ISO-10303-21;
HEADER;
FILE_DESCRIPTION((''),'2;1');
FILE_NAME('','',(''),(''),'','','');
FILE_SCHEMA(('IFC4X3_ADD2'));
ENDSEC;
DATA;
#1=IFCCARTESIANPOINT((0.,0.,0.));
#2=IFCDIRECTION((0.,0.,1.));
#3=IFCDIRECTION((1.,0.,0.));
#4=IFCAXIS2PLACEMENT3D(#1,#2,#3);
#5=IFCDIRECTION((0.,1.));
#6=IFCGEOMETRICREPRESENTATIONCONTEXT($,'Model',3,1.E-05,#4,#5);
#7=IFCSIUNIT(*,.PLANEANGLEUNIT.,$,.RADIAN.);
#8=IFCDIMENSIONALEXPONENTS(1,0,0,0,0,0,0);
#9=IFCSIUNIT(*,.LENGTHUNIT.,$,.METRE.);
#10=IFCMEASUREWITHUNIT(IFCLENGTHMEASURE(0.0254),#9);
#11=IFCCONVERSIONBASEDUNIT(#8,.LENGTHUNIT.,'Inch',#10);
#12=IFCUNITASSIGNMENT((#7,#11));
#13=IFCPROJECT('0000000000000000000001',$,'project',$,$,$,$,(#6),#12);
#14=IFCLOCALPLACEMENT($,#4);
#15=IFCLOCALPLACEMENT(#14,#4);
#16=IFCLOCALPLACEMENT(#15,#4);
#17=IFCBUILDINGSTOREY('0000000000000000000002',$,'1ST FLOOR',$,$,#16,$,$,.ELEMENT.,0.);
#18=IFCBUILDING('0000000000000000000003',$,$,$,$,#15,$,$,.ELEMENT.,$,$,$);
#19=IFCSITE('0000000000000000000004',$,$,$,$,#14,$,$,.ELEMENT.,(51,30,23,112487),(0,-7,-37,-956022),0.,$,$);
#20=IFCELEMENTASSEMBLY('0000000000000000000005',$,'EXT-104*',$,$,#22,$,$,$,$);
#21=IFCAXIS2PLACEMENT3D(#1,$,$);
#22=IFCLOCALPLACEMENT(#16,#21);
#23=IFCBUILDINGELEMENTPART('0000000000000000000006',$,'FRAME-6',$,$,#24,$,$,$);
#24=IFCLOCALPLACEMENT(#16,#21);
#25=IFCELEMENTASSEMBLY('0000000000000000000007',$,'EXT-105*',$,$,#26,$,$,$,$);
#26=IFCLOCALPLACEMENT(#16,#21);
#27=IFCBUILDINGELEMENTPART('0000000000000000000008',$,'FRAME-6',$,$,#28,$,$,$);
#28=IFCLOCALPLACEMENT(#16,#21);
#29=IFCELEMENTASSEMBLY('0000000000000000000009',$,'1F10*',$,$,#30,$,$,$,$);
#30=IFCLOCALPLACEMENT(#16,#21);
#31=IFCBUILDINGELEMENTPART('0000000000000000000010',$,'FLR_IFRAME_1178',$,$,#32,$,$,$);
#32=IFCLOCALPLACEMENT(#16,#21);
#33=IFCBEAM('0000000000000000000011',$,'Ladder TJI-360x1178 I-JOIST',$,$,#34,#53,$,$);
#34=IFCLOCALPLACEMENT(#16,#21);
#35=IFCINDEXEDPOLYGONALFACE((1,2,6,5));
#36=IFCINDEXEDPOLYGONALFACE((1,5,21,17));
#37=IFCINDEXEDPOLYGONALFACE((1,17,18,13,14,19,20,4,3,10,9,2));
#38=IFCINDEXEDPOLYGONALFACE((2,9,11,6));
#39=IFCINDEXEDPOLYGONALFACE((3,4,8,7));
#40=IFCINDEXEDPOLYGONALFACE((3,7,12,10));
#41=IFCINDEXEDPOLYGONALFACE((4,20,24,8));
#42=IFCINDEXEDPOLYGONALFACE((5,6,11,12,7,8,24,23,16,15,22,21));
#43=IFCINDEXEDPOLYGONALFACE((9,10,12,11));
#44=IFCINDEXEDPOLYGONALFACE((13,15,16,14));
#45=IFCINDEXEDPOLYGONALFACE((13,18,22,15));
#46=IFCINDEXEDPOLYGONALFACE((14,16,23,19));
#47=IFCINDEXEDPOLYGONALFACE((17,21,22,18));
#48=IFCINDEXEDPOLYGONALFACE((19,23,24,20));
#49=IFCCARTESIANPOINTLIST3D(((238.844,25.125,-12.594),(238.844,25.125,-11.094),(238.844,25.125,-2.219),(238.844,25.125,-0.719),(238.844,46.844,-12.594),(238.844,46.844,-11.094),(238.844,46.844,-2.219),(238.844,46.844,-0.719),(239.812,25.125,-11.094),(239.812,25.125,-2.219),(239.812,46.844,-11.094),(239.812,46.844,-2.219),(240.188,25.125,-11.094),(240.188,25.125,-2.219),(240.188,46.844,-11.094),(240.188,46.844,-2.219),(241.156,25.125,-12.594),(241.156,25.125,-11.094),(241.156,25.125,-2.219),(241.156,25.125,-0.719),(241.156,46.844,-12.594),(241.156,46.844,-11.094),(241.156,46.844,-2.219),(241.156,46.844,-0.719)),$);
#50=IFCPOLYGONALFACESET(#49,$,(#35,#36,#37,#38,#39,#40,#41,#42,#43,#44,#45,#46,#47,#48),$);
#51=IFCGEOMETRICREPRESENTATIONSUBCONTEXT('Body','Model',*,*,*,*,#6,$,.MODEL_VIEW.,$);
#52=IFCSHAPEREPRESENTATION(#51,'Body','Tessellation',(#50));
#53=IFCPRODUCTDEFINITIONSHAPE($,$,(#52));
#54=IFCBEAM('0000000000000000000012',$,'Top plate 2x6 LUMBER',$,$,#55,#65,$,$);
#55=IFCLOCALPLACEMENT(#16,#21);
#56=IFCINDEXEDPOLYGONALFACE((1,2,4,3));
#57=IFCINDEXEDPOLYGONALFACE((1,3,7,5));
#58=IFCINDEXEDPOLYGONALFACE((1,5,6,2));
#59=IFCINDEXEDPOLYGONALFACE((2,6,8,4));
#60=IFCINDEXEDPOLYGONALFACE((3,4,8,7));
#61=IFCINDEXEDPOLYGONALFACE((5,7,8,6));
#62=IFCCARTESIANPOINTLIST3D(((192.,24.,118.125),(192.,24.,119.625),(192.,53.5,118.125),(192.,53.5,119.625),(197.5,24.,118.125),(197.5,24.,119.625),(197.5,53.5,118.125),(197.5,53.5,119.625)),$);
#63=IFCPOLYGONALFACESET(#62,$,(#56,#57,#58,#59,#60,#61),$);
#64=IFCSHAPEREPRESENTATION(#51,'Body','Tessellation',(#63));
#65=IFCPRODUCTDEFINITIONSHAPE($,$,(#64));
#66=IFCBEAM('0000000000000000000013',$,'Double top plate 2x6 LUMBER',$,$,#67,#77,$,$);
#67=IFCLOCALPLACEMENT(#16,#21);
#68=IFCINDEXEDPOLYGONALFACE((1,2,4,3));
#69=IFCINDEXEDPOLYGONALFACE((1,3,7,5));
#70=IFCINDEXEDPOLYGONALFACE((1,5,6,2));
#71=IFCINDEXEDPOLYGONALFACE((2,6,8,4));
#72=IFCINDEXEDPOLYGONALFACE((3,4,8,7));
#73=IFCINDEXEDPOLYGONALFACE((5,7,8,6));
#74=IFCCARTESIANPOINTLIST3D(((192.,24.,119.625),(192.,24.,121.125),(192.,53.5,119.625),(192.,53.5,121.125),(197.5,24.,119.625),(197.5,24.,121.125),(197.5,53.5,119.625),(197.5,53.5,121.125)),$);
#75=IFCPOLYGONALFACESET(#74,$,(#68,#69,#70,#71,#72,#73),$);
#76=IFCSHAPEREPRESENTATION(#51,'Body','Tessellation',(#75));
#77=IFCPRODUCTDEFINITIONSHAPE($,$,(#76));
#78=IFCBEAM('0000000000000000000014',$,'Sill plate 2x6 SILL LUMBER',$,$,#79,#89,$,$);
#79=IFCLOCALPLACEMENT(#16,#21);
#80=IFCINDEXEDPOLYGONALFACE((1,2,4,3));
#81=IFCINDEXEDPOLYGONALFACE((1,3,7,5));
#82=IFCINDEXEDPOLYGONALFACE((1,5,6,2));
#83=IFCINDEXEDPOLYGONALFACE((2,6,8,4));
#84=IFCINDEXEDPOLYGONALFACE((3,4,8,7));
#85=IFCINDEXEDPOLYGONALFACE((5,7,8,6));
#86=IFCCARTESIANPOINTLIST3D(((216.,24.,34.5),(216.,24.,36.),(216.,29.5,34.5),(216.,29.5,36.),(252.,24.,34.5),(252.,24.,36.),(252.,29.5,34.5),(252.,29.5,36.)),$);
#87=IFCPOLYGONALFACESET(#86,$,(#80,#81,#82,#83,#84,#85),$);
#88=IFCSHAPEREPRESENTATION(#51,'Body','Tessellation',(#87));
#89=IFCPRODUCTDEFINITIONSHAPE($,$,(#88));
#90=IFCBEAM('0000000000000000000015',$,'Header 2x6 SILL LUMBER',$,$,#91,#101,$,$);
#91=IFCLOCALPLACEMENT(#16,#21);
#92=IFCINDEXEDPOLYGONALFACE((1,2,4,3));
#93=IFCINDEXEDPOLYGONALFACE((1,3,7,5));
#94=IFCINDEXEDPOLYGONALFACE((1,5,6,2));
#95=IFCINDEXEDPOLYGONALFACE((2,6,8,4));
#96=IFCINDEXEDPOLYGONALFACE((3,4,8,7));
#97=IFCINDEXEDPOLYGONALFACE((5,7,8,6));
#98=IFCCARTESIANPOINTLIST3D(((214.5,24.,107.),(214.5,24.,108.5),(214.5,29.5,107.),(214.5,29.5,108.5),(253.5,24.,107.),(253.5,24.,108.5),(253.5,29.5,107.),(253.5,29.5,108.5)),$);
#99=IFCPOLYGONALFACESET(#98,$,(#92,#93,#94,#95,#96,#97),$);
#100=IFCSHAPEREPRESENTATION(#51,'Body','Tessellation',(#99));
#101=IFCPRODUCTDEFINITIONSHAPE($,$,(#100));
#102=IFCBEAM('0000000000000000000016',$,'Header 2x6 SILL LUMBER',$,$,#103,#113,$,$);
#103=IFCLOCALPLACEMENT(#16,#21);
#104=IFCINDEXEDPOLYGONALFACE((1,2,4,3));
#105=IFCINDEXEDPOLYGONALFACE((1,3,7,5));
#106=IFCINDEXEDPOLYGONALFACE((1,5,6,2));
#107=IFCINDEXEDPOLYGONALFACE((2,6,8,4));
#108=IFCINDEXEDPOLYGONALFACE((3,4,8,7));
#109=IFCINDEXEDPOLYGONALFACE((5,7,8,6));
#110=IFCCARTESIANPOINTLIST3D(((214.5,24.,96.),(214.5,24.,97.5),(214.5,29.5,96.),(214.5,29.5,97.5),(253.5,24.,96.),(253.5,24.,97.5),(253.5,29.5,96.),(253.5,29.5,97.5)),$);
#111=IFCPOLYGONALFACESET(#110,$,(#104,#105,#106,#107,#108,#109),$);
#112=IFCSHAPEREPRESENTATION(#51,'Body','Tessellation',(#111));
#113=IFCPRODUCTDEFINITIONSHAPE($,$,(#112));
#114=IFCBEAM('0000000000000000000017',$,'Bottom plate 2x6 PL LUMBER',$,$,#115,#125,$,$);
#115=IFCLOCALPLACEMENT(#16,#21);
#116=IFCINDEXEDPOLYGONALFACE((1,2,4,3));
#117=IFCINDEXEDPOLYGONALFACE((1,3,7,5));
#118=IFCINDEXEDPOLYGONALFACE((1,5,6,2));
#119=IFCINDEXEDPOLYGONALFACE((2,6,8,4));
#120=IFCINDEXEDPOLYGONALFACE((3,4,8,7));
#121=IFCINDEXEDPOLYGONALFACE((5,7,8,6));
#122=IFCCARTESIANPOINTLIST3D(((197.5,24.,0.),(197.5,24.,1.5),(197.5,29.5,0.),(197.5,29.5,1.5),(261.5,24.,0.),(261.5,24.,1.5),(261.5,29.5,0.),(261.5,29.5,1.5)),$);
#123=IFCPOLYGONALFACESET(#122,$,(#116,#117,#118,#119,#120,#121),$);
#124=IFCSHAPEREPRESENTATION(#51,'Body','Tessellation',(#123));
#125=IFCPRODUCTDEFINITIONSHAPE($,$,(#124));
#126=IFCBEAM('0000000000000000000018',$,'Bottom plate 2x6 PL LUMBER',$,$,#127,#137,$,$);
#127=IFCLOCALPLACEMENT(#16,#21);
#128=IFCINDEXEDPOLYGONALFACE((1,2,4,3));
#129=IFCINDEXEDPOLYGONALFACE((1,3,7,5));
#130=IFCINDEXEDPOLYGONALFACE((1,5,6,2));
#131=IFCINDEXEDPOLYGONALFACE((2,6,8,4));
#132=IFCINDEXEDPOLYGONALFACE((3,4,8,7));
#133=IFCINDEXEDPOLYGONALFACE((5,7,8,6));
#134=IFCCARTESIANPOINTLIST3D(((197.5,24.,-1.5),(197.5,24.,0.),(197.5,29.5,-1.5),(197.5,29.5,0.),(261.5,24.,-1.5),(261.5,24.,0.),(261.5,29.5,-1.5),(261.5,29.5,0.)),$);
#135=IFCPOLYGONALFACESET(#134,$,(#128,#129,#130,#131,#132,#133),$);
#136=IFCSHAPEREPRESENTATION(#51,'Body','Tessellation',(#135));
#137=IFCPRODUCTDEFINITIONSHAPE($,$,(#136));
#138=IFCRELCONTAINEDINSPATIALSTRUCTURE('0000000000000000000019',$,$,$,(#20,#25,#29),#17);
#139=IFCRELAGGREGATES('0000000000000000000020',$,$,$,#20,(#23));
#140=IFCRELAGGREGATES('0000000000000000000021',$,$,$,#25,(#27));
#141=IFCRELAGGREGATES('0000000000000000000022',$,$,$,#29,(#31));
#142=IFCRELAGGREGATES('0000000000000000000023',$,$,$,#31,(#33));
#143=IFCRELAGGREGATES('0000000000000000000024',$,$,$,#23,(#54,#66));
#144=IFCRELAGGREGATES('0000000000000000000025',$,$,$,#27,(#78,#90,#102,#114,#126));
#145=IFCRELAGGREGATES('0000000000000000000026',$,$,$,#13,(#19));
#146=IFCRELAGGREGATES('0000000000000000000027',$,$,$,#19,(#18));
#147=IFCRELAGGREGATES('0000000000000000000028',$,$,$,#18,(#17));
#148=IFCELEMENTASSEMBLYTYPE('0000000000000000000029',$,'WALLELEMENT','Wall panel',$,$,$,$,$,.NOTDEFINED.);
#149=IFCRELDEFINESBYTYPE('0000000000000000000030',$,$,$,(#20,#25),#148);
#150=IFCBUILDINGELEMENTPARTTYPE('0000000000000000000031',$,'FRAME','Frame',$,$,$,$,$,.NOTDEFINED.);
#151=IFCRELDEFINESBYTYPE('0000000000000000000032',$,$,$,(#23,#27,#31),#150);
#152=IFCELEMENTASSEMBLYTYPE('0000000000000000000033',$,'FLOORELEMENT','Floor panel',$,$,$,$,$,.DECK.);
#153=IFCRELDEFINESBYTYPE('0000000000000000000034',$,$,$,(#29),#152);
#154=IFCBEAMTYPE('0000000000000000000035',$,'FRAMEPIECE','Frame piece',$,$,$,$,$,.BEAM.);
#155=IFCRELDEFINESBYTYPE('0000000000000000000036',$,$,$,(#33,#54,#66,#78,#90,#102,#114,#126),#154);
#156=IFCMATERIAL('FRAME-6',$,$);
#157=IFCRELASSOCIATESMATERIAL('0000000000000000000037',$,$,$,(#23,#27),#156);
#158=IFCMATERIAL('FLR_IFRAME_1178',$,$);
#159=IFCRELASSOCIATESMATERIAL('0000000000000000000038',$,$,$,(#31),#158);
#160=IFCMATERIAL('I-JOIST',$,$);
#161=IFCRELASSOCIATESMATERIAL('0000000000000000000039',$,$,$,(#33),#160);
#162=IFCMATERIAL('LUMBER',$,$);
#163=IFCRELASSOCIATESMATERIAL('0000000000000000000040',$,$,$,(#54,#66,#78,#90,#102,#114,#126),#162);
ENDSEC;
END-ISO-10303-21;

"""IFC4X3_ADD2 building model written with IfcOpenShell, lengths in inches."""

from ifc_helpers import new_model, entity, si_unit, converted_unit, direction, frame, origin_with_axes, origin_2d_with_axis, place, context, subcontext, project, spatial, rectangle, i_section, extrude, material, type_object, element, aggregate, save


model = new_model("IFC4X3_ADD2")

# Units and contexts
model_context = context("Model", 3, precision=1e-05, world=origin_with_axes(), true_north=direction((0.0, 1.0)))
body_context = subcontext(model_context, "Body", "Model", "MODEL_VIEW")
ifc_project = project(units=[si_unit("PLANEANGLEUNIT", "RADIAN"), converted_unit("LENGTHUNIT", "Inch", entity("IfcLengthMeasure", 0.0254), si_unit("LENGTHUNIT", "METRE"), dimensions=[1, 0, 0, 0, 0, 0, 0])], contexts=[model_context])

# Site, building, storey
site_placement = place(None, origin_with_axes())
site = spatial("IfcSite", under=ifc_project, at=site_placement, CompositionType="ELEMENT", RefLatitude=(51, 30, 23, 112487), RefLongitude=(0, -7, -37, -956022), RefElevation=0.0)
building_placement = place(site_placement, origin_with_axes())
building = spatial("IfcBuilding", under=site, at=building_placement, CompositionType="ELEMENT")
storey_placement = place(building_placement, origin_with_axes())
storey = spatial("IfcBuildingStorey", under=building, at=storey_placement, Name="1ST FLOOR", CompositionType="ELEMENT", Elevation=0.0)

# Element assembly, building element part
element_assembly_type_1 = type_object("IfcElementAssemblyType", Name="WALLELEMENT", Description="Wall panel", PredefinedType="NOTDEFINED")
assembly_1_placement = place(storey_placement, origin_with_axes())
assembly_1 = element("IfcElementAssembly", 1, at=assembly_1_placement, inside=storey, type_object=element_assembly_type_1, Name="EXT-104*")
ifc_material_1 = material(Name="FRAME-6")
building_element_part_type = type_object("IfcBuildingElementPartType", Name="FRAME", Description="Frame", PredefinedType="NOTDEFINED")
building_element_part_1_placement = place(storey_placement, origin_with_axes())
building_element_part_1 = element("IfcBuildingElementPart", 2, at=building_element_part_1_placement, type_object=building_element_part_type, material=ifc_material_1, Name="FRAME-6")
aggregate(assembly_1, [building_element_part_1])
ifc_material_2 = material(Name="LUMBER")

# Element assembly, building element part
assembly_2_placement = place(storey_placement, origin_with_axes())
assembly_2 = element("IfcElementAssembly", 3, at=assembly_2_placement, inside=storey, type_object=element_assembly_type_1, Name="EXT-105*")
building_element_part_2_placement = place(storey_placement, origin_with_axes())
building_element_part_2 = element("IfcBuildingElementPart", 4, at=building_element_part_2_placement, type_object=building_element_part_type, material=ifc_material_1, Name="FRAME-6")
aggregate(assembly_2, [building_element_part_2])

# Element assembly, building element part, beam
element_assembly_type_2 = type_object("IfcElementAssemblyType", Name="FLOORELEMENT", Description="Floor panel", PredefinedType="DECK")
assembly_3_placement = place(storey_placement, origin_with_axes())
assembly_3 = element("IfcElementAssembly", 5, at=assembly_3_placement, inside=storey, type_object=element_assembly_type_2, Name="1F10*")
ifc_material_3 = material(Name="FLR_IFRAME_1178")
building_element_part_3_placement = place(storey_placement, origin_with_axes())
building_element_part_3 = element("IfcBuildingElementPart", 6, at=building_element_part_3_placement, type_object=building_element_part_type, material=ifc_material_3, Name="FLR_IFRAME_1178")
aggregate(assembly_3, [building_element_part_3])
ifc_material_4 = material(Name="I-JOIST")
beam_type = type_object("IfcBeamType", Name="FRAMEPIECE", Description="Frame piece", PredefinedType="BEAM")
beam_1_placement = place(storey_placement, frame((240.0, 25.125, -6.656), z_axis=(0.0, 1.0, 0.0), x_axis=(-1.0, 0.0, 0.0)))
beam_1 = element("IfcBeam", 7, at=beam_1_placement, type_object=beam_type, material=ifc_material_4, Name="Ladder TJI-360x1178 I-JOIST", context=body_context, shape_type="SweptSolid", body=[
    extrude(i_section(OverallWidth=2.313, OverallDepth=11.875, WebThickness=0.375, FlangeThickness=1.5, at=origin_2d_with_axis()), origin_with_axes(), (0.0, 0.0, 1.0), 21.719),
])
aggregate(building_element_part_3, [beam_1])

# Beams
beam_2_placement = place(storey_placement, frame((194.75, 24.0, 118.875), z_axis=(0.0, 1.0, 0.0), x_axis=(0.0, 0.0, -1.0)))
beam_2 = element("IfcBeam", 8, at=beam_2_placement, type_object=beam_type, material=ifc_material_2, Name="Top plate 2x6 LUMBER", context=body_context, shape_type="SweptSolid", body=[
    extrude(rectangle(XDim=1.5, YDim=5.5, at=origin_2d_with_axis()), origin_with_axes(), (0.0, 0.0, 1.0), 29.5),
])
beam_3_placement = place(storey_placement, frame((194.75, 24.0, 120.375), z_axis=(0.0, 1.0, 0.0), x_axis=(0.0, 0.0, -1.0)))
beam_3 = element("IfcBeam", 9, at=beam_3_placement, type_object=beam_type, material=ifc_material_2, Name="Double top plate 2x6 LUMBER", context=body_context, shape_type="SweptSolid", body=[
    extrude(rectangle(XDim=1.5, YDim=5.5, at=origin_2d_with_axis()), origin_with_axes(), (0.0, 0.0, 1.0), 29.5),
])
aggregate(building_element_part_1, [beam_2, beam_3])
beam_4_placement = place(storey_placement, frame((252.0, 26.75, 35.25), z_axis=(-1.0, 0.0, 0.0), x_axis=(0.0, 0.0, -1.0)))
beam_4 = element("IfcBeam", 10, at=beam_4_placement, type_object=beam_type, material=ifc_material_2, Name="Sill plate 2x6 SILL LUMBER", context=body_context, shape_type="SweptSolid", body=[
    extrude(rectangle(XDim=1.5, YDim=5.5, at=origin_2d_with_axis()), origin_with_axes(), (0.0, 0.0, 1.0), 36.0),
])
beam_5_placement = place(storey_placement, frame((214.5, 26.75, 107.75), z_axis=(1.0, 0.0, 0.0), x_axis=(0.0, 0.0, 1.0)))
beam_5 = element("IfcBeam", 11, at=beam_5_placement, type_object=beam_type, material=ifc_material_2, Name="Header 2x6 SILL LUMBER", context=body_context, shape_type="SweptSolid", body=[
    extrude(rectangle(XDim=1.5, YDim=5.5, at=origin_2d_with_axis()), origin_with_axes(), (0.0, 0.0, 1.0), 39.0),
])
beam_6_placement = place(storey_placement, frame((214.5, 26.75, 96.75), z_axis=(1.0, 0.0, 0.0), x_axis=(0.0, 0.0, 1.0)))
beam_6 = element("IfcBeam", 12, at=beam_6_placement, type_object=beam_type, material=ifc_material_2, Name="Header 2x6 SILL LUMBER", context=body_context, shape_type="SweptSolid", body=[
    extrude(rectangle(XDim=1.5, YDim=5.5, at=origin_2d_with_axis()), origin_with_axes(), (0.0, 0.0, 1.0), 39.0),
])
beam_7_placement = place(storey_placement, frame((197.5, 26.75, 0.75), z_axis=(1.0, 0.0, 0.0), x_axis=(0.0, 0.0, 1.0)))
beam_7 = element("IfcBeam", 13, at=beam_7_placement, type_object=beam_type, material=ifc_material_2, Name="Bottom plate 2x6 PL LUMBER", context=body_context, shape_type="SweptSolid", body=[
    extrude(rectangle(XDim=1.5, YDim=5.5, at=origin_2d_with_axis()), origin_with_axes(), (0.0, 0.0, 1.0), 64.0),
])
beam_8_placement = place(storey_placement, frame((197.5, 26.75, -0.75), z_axis=(1.0, 0.0, 0.0), x_axis=(0.0, 0.0, 1.0)))
beam_8 = element("IfcBeam", 14, at=beam_8_placement, type_object=beam_type, material=ifc_material_2, Name="Bottom plate 2x6 PL LUMBER", context=body_context, shape_type="SweptSolid", body=[
    extrude(rectangle(XDim=1.5, YDim=5.5, at=origin_2d_with_axis()), origin_with_axes(), (0.0, 0.0, 1.0), 64.0),
])
aggregate(building_element_part_2, [beam_4, beam_5, beam_6, beam_7, beam_8])

save(model, "model.ifc")
